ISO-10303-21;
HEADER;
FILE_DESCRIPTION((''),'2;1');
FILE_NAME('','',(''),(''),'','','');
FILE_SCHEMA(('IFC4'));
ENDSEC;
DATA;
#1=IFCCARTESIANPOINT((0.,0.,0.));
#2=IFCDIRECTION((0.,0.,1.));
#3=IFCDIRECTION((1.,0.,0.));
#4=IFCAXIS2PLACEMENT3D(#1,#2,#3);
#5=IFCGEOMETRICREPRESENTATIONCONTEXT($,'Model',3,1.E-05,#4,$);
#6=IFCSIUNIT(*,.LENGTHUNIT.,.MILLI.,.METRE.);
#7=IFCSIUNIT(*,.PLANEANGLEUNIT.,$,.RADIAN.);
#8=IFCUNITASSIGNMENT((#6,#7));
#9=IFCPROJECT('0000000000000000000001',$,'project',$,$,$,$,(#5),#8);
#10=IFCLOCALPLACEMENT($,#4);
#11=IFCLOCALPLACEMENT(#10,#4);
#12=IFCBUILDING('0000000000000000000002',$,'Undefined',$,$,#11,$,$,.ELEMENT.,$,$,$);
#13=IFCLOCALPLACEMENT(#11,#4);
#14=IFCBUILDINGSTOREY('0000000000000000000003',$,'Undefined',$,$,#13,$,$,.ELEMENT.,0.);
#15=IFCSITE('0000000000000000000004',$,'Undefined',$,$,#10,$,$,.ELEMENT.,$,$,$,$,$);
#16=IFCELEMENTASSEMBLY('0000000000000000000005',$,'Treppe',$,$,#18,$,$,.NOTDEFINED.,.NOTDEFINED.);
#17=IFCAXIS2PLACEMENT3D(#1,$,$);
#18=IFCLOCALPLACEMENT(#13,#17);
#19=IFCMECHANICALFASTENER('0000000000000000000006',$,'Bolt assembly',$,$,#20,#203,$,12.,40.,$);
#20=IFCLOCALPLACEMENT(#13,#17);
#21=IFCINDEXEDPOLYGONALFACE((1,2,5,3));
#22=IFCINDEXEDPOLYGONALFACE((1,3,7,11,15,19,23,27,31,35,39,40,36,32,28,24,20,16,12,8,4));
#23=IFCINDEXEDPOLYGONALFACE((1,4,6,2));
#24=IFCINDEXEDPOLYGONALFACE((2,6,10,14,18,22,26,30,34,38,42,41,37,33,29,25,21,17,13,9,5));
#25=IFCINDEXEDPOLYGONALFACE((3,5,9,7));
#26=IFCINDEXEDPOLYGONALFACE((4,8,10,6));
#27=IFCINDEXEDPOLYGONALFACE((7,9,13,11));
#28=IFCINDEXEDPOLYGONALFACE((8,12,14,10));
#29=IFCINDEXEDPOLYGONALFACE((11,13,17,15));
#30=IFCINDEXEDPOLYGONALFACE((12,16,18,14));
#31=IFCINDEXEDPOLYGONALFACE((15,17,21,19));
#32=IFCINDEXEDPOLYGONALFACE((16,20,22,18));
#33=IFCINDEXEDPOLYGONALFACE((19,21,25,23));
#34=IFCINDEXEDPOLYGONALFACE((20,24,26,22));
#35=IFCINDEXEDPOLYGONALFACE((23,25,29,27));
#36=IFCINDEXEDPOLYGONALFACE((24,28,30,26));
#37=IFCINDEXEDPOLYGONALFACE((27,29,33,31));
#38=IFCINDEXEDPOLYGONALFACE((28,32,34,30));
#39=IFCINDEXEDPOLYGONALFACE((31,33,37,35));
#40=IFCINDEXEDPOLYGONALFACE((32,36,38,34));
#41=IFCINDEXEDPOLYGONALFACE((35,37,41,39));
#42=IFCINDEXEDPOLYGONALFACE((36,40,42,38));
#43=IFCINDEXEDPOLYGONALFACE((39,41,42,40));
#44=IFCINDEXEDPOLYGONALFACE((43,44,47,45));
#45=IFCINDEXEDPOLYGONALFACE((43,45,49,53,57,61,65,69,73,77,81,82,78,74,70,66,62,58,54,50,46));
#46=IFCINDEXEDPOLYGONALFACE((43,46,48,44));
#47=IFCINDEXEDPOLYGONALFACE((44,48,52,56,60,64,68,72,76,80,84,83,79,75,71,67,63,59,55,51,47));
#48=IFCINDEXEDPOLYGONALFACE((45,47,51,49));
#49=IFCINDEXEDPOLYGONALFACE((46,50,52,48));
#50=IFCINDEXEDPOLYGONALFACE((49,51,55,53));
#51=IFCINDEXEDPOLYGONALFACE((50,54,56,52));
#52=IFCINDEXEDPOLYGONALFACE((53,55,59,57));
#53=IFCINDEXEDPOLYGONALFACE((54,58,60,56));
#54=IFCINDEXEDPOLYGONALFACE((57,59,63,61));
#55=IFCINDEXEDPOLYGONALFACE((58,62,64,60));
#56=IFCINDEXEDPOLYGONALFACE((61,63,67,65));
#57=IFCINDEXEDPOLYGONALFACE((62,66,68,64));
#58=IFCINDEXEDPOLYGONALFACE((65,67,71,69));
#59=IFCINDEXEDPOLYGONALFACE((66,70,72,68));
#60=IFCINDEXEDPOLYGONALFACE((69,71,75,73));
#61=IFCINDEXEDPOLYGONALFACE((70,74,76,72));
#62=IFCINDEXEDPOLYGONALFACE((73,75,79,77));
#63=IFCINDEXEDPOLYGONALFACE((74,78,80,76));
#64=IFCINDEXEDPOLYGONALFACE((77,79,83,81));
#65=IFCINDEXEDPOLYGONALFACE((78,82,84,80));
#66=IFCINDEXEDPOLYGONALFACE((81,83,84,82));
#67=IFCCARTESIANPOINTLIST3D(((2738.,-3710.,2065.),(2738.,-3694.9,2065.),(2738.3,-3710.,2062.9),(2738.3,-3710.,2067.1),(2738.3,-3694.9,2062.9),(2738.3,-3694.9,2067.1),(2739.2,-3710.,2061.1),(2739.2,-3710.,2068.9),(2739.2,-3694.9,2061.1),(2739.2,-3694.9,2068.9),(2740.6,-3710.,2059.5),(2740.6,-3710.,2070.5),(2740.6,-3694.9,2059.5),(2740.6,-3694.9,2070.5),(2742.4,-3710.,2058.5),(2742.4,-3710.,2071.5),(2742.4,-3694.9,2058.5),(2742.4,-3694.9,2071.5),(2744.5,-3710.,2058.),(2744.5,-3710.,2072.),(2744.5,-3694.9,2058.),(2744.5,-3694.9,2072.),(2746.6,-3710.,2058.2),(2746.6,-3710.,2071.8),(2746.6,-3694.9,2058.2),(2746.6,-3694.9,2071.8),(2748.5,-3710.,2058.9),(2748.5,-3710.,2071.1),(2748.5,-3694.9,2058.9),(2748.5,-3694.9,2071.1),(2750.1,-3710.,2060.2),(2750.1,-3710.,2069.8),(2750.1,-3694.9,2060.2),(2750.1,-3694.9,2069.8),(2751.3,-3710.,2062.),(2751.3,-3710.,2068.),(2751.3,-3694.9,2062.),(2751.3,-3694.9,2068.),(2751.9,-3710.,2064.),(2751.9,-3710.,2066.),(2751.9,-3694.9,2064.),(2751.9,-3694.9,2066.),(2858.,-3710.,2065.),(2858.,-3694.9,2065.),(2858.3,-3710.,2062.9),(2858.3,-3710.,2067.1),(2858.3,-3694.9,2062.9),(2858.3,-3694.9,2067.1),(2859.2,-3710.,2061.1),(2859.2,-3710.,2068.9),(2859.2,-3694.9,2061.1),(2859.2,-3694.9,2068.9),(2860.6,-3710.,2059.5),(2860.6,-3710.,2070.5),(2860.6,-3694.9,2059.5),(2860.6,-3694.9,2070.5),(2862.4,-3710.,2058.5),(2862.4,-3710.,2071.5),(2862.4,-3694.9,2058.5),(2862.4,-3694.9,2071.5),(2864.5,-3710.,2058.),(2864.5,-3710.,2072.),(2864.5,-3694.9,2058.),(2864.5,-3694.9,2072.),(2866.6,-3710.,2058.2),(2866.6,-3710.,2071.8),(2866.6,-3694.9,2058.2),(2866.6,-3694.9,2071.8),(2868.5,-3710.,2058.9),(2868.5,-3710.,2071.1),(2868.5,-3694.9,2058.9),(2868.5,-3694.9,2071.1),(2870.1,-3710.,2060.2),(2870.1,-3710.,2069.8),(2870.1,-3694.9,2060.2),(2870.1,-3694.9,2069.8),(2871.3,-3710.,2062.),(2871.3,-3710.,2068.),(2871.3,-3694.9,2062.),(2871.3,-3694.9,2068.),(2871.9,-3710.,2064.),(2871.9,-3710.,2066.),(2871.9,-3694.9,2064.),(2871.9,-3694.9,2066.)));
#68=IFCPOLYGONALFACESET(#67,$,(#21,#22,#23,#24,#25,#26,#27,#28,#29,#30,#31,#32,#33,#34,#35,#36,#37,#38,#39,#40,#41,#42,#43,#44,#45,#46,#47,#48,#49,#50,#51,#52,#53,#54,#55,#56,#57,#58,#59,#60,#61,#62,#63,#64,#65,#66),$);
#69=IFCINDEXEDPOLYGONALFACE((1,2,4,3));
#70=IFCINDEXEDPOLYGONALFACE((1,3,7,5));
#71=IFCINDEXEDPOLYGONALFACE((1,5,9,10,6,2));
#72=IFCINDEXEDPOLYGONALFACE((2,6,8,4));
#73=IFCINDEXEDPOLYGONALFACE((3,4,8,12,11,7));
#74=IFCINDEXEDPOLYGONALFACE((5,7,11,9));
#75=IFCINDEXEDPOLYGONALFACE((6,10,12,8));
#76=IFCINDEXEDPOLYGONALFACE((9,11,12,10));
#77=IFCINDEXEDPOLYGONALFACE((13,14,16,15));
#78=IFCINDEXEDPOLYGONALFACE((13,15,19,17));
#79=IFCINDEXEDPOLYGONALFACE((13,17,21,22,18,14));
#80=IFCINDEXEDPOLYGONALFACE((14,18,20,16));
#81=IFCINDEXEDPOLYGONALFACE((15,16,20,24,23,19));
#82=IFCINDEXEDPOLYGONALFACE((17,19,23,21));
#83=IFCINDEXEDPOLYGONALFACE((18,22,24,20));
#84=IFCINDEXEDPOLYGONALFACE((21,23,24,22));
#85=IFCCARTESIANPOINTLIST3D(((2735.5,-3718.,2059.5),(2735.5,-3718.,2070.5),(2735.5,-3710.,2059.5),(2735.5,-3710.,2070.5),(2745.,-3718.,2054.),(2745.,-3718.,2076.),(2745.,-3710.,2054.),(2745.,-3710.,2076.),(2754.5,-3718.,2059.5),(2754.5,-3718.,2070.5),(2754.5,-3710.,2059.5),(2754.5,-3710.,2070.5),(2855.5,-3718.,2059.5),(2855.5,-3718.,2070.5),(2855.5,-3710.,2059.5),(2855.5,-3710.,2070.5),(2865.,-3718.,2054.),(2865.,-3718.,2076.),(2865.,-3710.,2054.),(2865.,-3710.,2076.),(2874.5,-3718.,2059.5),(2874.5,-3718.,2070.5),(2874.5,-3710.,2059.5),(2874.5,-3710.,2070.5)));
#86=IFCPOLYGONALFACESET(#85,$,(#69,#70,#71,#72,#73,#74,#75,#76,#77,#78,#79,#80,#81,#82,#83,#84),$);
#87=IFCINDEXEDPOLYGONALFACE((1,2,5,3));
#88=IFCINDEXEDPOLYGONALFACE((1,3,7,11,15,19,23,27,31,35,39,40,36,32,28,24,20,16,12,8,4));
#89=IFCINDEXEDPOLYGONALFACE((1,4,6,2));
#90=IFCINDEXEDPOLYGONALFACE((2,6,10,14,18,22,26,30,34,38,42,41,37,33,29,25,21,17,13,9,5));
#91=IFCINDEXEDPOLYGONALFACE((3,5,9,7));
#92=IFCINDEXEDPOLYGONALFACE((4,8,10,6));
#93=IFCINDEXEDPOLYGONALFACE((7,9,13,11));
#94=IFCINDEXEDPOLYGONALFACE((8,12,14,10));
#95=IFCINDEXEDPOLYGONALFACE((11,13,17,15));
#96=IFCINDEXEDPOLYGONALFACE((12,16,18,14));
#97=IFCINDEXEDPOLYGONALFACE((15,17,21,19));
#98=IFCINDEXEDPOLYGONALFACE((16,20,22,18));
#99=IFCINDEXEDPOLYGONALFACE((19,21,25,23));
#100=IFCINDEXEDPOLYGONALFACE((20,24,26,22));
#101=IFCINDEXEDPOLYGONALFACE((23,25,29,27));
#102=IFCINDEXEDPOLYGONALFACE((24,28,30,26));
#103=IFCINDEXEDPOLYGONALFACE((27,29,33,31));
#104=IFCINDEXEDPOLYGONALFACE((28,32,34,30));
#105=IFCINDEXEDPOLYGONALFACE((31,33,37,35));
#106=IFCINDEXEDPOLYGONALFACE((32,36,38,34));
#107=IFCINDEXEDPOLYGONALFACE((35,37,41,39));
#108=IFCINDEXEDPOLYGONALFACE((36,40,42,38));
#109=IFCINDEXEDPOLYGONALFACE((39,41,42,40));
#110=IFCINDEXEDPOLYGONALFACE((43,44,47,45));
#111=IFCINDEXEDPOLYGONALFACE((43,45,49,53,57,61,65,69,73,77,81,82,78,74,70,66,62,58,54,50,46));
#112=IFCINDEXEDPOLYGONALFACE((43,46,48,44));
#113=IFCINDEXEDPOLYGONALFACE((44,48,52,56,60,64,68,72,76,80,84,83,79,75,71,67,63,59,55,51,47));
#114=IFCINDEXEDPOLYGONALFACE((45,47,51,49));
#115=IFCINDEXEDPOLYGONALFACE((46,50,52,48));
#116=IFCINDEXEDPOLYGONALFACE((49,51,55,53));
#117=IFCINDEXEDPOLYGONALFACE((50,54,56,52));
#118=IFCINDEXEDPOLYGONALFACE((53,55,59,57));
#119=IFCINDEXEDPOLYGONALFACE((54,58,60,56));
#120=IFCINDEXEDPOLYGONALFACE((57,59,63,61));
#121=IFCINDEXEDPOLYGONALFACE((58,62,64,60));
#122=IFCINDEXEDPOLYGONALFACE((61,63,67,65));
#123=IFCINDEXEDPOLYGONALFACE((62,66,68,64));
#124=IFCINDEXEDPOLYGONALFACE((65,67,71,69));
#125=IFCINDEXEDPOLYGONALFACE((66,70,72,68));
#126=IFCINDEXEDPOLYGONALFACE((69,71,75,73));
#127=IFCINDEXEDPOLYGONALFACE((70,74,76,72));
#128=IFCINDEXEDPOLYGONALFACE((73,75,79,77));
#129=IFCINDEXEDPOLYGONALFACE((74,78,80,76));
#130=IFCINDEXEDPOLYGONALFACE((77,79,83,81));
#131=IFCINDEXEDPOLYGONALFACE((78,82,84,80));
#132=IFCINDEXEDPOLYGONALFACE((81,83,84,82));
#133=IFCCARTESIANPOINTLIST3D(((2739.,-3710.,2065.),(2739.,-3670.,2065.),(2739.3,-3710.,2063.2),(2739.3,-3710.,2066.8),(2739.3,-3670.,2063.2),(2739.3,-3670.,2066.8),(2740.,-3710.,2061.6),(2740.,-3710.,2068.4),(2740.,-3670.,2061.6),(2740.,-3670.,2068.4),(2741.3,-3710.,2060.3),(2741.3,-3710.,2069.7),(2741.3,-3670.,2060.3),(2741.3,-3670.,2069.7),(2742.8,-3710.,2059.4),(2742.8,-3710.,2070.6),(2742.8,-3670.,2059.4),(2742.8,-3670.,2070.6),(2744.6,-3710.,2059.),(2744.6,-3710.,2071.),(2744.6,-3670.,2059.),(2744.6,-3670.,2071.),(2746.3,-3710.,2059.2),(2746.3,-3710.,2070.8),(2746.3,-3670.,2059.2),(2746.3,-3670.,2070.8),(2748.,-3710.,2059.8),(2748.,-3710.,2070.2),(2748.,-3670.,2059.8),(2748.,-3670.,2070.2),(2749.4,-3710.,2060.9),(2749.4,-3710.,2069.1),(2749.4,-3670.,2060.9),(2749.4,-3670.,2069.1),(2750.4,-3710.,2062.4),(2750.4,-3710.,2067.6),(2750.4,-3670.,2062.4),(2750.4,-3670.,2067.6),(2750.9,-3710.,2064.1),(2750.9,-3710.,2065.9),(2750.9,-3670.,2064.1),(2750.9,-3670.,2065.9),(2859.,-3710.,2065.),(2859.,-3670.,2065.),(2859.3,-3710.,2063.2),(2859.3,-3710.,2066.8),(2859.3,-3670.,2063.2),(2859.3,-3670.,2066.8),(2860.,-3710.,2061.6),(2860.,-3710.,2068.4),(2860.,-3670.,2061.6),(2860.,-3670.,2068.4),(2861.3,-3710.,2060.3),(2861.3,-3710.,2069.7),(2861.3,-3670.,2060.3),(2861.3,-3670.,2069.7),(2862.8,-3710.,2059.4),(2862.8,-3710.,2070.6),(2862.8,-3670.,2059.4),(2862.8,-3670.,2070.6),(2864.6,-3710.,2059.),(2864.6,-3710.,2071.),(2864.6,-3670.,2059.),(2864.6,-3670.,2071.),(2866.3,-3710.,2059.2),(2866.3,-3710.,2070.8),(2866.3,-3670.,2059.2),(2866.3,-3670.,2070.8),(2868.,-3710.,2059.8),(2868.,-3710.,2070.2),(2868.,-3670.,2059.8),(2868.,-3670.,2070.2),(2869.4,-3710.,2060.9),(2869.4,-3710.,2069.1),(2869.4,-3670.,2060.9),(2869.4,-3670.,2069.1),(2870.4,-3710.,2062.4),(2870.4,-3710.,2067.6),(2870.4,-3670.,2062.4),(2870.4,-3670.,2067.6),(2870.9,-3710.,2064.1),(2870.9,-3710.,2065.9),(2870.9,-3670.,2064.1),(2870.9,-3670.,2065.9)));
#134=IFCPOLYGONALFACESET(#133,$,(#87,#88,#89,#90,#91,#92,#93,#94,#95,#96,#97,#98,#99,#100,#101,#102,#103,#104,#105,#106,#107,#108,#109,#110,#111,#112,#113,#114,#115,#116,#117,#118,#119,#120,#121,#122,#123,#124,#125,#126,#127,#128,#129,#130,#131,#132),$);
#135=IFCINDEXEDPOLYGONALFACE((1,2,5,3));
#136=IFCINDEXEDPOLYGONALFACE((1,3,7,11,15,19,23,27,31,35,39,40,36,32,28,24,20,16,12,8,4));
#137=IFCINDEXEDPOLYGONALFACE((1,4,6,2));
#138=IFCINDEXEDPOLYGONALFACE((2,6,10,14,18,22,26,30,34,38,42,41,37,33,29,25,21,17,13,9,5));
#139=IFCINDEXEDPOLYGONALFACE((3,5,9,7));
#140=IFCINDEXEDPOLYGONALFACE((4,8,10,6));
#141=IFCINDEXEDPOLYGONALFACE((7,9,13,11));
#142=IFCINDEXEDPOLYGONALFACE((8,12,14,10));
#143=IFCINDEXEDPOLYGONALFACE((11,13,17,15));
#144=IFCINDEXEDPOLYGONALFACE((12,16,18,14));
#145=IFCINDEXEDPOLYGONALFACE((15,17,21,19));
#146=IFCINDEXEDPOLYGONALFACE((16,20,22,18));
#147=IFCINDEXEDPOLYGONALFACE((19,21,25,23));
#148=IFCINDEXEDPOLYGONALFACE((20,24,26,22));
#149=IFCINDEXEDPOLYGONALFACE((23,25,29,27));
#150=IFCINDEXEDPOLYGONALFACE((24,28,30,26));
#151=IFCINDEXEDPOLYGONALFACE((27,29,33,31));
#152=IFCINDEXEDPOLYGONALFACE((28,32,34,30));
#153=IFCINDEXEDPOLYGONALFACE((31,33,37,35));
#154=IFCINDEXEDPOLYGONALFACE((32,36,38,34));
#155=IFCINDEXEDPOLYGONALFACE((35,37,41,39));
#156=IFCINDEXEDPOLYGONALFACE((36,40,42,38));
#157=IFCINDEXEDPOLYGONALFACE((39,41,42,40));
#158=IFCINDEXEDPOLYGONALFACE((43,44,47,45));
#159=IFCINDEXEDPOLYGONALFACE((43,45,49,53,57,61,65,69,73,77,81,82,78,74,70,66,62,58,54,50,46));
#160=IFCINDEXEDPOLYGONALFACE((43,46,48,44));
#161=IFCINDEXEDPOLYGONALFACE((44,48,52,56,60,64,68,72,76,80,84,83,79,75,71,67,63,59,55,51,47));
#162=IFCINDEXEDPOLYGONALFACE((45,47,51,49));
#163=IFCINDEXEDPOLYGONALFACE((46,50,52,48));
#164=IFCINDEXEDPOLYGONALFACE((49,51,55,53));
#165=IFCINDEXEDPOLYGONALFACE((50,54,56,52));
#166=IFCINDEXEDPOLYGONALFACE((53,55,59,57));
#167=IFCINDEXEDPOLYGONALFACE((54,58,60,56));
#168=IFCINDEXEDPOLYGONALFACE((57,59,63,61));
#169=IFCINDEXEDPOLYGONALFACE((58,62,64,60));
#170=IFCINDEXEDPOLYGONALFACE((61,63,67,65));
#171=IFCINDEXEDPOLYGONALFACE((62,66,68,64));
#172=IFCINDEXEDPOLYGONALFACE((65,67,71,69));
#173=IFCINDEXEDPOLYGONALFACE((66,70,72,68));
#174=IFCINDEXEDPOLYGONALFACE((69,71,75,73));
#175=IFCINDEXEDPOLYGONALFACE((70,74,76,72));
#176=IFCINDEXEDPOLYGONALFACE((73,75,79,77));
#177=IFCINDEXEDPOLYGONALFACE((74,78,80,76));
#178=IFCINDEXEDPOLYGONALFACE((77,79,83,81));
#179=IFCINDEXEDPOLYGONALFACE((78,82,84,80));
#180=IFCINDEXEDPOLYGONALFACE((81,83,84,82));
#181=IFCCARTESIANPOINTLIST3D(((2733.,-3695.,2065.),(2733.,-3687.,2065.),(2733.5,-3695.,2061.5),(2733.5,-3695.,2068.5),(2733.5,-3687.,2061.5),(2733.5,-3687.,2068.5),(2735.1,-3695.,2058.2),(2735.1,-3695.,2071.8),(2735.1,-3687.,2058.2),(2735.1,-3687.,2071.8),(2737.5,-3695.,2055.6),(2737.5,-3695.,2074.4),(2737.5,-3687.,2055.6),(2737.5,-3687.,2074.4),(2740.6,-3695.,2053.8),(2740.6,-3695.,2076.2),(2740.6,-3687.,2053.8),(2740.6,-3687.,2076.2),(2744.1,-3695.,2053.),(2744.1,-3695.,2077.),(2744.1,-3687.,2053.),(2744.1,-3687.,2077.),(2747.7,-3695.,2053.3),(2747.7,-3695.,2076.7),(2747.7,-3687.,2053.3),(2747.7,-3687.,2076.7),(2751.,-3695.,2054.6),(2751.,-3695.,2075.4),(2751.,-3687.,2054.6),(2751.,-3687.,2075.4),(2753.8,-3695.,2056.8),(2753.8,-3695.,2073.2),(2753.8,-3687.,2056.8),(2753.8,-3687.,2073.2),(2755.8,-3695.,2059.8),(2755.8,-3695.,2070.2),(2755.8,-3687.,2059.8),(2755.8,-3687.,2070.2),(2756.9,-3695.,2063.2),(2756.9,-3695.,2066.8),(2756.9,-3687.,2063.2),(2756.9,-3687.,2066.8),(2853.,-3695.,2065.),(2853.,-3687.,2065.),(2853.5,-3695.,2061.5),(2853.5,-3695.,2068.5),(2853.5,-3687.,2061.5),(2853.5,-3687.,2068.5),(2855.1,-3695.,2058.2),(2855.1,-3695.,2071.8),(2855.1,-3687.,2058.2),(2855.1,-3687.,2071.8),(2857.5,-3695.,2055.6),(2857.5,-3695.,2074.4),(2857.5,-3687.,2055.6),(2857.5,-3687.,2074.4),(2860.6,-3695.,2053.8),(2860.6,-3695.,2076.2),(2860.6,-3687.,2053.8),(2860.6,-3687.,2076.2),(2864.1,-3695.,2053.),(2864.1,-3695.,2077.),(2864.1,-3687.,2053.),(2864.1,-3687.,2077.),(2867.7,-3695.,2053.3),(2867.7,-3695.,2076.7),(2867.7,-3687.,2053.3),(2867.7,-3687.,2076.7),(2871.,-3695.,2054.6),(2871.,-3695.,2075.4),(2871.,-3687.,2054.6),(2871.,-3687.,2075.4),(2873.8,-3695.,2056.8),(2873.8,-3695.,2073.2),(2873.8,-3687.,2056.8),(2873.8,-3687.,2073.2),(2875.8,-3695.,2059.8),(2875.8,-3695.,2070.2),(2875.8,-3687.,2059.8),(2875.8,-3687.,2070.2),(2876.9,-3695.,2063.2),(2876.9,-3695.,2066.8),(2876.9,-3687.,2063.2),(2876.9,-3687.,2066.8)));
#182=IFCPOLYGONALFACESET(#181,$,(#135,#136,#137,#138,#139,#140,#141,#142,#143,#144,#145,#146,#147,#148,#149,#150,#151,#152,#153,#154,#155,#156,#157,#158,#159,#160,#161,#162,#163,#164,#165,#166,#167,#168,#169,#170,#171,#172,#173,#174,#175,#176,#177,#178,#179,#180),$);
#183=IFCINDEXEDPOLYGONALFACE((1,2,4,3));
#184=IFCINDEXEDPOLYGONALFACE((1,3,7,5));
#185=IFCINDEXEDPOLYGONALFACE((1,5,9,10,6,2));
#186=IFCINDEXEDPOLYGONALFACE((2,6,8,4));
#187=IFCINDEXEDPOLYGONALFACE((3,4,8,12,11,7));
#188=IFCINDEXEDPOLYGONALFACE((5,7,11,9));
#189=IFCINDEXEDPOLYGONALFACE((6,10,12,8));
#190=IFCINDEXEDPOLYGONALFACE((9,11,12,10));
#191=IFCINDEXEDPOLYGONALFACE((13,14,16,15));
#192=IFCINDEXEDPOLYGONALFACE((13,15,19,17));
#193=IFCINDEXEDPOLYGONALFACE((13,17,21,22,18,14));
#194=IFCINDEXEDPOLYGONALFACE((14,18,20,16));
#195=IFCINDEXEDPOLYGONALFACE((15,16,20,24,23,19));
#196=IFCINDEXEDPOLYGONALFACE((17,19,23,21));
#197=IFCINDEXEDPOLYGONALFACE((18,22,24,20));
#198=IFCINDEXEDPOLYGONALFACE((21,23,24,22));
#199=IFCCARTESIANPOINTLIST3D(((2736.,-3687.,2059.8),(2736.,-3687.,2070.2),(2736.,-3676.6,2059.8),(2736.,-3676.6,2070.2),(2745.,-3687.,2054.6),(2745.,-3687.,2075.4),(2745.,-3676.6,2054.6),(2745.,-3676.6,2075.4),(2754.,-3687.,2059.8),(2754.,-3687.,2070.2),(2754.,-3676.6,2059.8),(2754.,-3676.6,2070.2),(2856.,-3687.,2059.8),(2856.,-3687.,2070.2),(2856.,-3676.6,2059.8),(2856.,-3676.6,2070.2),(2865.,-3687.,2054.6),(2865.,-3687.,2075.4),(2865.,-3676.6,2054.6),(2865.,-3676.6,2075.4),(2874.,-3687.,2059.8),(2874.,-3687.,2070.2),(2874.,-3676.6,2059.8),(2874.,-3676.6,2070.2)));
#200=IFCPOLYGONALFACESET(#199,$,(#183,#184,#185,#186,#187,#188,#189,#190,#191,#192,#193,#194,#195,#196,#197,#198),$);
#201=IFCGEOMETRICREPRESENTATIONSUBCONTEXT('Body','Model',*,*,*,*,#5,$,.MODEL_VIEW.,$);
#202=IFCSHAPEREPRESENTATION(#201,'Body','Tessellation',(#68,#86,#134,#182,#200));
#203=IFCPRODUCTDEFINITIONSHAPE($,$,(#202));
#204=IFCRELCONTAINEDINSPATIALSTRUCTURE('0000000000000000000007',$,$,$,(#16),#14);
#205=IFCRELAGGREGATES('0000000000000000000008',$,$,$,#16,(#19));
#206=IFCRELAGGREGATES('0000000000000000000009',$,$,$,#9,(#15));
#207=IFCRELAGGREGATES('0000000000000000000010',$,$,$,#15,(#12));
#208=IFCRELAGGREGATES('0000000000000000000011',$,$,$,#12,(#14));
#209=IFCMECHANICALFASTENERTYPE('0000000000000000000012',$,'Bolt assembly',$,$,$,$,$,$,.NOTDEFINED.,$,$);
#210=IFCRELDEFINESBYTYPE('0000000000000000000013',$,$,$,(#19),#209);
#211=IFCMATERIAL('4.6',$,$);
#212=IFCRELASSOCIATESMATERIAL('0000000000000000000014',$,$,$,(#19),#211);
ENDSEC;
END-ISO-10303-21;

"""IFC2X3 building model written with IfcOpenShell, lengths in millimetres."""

from ifc_helpers import new_model, si_unit, frame, origin_with_axes, origin_2d_with_axis, place, context, subcontext, project, spatial, polyline, circle, outline, extrude, source, transform, mapped, material, type_object, element, aggregate, save


model = new_model("IFC2X3")

# Units and contexts
model_context = context("Model", 3, precision=1e-05, world=origin_with_axes())
body_context = subcontext(model_context, "Body", "Model", "MODEL_VIEW")
ifc_project = project(units=[si_unit("LENGTHUNIT", "METRE", prefix="MILLI"), si_unit("PLANEANGLEUNIT", "RADIAN")], contexts=[model_context])

# Site, building, storey
site_placement = place(None, origin_with_axes())
site = spatial("IfcSite", under=ifc_project, at=site_placement, Name="Undefined", CompositionType="ELEMENT")
building_placement = place(site_placement, origin_with_axes())
building = spatial("IfcBuilding", under=site, at=building_placement, Name="Undefined", CompositionType="ELEMENT")
storey_placement = place(building_placement, origin_with_axes())
storey = spatial("IfcBuildingStorey", under=building, at=storey_placement, Name="Undefined", CompositionType="ELEMENT", Elevation=0.0)

# Element assembly, mechanical fastener
assembly_1_placement = place(storey_placement, origin_with_axes())
assembly_1 = element("IfcElementAssembly", 1, at=assembly_1_placement, inside=storey, Name="Treppe", AssemblyPlace="NOTDEFINED", PredefinedType="NOTDEFINED")
ifc_material_1 = material(Name="4.6")
mechanical_fastener_type = type_object("IfcMechanicalFastenerType", Name="Bolt assembly")
shared_shape_1 = source(origin_with_axes(), body_context, "Body", "SweptSolid", [
    extrude(circle(Radius=7.0, at=origin_2d_with_axis()), frame((0.0, 0.0, 0.0), z_axis=(0.0, 1.0, 0.0), x_axis=(1.0, 0.0, 0.0)), (0.0, 0.0, 1.0), 15.1),
    extrude(outline(polyline([(9.5, -5.5), (9.5, 5.5), (0.0, 11.0), (-9.5, 5.5), (-9.5, -5.5), (0.0, -11.0), (9.5, -5.5)])), frame((0.0, -8.0, 0.0), z_axis=(0.0, 1.0, 0.0), x_axis=(1.0, 0.0, 0.0)), (0.0, 0.0, 1.0), 8.0),
    extrude(circle(Radius=6.0, at=origin_2d_with_axis()), frame((0.0, 0.0, 0.0), z_axis=(0.0, 1.0, 0.0), x_axis=(1.0, 0.0, 0.0)), (0.0, 0.0, 1.0), 40.0),
    extrude(circle(Radius=12.0, at=origin_2d_with_axis()), frame((0.0, 15.0, 0.0), z_axis=(0.0, 1.0, 0.0), x_axis=(1.0, 0.0, 0.0)), (0.0, 0.0, 1.0), 8.0),
    extrude(outline(polyline([(9.0, -5.2), (9.0, 5.2), (0.0, 10.4), (-9.0, 5.2), (-9.0, -5.2), (0.0, -10.4), (9.0, -5.2)])), frame((0.0, 23.0, 0.0), z_axis=(0.0, 1.0, 0.0), x_axis=(1.0, 0.0, 0.0)), (0.0, 0.0, 1.0), 10.4),
])
mechanical_fastener_1_placement = place(assembly_1_placement, frame((2865.0, -3710.0, 2065.0), z_axis=(0.0, 0.0, -1.0), x_axis=(-1.0, 0.0, 0.0)))
mechanical_fastener_1 = element("IfcMechanicalFastener", 2, at=mechanical_fastener_1_placement, type_object=mechanical_fastener_type, material=ifc_material_1, Name="Bolt assembly", NominalDiameter=12.0, NominalLength=40.0, context=body_context, shape_type="MappedRepresentation", body=[
    mapped(shared_shape_1, transform((0.0, 0.0, 0.0))),
    mapped(shared_shape_1, transform((120.0, 0.0, 0.0))),
])
aggregate(assembly_1, [mechanical_fastener_1])

save(model, "model.ifc")
